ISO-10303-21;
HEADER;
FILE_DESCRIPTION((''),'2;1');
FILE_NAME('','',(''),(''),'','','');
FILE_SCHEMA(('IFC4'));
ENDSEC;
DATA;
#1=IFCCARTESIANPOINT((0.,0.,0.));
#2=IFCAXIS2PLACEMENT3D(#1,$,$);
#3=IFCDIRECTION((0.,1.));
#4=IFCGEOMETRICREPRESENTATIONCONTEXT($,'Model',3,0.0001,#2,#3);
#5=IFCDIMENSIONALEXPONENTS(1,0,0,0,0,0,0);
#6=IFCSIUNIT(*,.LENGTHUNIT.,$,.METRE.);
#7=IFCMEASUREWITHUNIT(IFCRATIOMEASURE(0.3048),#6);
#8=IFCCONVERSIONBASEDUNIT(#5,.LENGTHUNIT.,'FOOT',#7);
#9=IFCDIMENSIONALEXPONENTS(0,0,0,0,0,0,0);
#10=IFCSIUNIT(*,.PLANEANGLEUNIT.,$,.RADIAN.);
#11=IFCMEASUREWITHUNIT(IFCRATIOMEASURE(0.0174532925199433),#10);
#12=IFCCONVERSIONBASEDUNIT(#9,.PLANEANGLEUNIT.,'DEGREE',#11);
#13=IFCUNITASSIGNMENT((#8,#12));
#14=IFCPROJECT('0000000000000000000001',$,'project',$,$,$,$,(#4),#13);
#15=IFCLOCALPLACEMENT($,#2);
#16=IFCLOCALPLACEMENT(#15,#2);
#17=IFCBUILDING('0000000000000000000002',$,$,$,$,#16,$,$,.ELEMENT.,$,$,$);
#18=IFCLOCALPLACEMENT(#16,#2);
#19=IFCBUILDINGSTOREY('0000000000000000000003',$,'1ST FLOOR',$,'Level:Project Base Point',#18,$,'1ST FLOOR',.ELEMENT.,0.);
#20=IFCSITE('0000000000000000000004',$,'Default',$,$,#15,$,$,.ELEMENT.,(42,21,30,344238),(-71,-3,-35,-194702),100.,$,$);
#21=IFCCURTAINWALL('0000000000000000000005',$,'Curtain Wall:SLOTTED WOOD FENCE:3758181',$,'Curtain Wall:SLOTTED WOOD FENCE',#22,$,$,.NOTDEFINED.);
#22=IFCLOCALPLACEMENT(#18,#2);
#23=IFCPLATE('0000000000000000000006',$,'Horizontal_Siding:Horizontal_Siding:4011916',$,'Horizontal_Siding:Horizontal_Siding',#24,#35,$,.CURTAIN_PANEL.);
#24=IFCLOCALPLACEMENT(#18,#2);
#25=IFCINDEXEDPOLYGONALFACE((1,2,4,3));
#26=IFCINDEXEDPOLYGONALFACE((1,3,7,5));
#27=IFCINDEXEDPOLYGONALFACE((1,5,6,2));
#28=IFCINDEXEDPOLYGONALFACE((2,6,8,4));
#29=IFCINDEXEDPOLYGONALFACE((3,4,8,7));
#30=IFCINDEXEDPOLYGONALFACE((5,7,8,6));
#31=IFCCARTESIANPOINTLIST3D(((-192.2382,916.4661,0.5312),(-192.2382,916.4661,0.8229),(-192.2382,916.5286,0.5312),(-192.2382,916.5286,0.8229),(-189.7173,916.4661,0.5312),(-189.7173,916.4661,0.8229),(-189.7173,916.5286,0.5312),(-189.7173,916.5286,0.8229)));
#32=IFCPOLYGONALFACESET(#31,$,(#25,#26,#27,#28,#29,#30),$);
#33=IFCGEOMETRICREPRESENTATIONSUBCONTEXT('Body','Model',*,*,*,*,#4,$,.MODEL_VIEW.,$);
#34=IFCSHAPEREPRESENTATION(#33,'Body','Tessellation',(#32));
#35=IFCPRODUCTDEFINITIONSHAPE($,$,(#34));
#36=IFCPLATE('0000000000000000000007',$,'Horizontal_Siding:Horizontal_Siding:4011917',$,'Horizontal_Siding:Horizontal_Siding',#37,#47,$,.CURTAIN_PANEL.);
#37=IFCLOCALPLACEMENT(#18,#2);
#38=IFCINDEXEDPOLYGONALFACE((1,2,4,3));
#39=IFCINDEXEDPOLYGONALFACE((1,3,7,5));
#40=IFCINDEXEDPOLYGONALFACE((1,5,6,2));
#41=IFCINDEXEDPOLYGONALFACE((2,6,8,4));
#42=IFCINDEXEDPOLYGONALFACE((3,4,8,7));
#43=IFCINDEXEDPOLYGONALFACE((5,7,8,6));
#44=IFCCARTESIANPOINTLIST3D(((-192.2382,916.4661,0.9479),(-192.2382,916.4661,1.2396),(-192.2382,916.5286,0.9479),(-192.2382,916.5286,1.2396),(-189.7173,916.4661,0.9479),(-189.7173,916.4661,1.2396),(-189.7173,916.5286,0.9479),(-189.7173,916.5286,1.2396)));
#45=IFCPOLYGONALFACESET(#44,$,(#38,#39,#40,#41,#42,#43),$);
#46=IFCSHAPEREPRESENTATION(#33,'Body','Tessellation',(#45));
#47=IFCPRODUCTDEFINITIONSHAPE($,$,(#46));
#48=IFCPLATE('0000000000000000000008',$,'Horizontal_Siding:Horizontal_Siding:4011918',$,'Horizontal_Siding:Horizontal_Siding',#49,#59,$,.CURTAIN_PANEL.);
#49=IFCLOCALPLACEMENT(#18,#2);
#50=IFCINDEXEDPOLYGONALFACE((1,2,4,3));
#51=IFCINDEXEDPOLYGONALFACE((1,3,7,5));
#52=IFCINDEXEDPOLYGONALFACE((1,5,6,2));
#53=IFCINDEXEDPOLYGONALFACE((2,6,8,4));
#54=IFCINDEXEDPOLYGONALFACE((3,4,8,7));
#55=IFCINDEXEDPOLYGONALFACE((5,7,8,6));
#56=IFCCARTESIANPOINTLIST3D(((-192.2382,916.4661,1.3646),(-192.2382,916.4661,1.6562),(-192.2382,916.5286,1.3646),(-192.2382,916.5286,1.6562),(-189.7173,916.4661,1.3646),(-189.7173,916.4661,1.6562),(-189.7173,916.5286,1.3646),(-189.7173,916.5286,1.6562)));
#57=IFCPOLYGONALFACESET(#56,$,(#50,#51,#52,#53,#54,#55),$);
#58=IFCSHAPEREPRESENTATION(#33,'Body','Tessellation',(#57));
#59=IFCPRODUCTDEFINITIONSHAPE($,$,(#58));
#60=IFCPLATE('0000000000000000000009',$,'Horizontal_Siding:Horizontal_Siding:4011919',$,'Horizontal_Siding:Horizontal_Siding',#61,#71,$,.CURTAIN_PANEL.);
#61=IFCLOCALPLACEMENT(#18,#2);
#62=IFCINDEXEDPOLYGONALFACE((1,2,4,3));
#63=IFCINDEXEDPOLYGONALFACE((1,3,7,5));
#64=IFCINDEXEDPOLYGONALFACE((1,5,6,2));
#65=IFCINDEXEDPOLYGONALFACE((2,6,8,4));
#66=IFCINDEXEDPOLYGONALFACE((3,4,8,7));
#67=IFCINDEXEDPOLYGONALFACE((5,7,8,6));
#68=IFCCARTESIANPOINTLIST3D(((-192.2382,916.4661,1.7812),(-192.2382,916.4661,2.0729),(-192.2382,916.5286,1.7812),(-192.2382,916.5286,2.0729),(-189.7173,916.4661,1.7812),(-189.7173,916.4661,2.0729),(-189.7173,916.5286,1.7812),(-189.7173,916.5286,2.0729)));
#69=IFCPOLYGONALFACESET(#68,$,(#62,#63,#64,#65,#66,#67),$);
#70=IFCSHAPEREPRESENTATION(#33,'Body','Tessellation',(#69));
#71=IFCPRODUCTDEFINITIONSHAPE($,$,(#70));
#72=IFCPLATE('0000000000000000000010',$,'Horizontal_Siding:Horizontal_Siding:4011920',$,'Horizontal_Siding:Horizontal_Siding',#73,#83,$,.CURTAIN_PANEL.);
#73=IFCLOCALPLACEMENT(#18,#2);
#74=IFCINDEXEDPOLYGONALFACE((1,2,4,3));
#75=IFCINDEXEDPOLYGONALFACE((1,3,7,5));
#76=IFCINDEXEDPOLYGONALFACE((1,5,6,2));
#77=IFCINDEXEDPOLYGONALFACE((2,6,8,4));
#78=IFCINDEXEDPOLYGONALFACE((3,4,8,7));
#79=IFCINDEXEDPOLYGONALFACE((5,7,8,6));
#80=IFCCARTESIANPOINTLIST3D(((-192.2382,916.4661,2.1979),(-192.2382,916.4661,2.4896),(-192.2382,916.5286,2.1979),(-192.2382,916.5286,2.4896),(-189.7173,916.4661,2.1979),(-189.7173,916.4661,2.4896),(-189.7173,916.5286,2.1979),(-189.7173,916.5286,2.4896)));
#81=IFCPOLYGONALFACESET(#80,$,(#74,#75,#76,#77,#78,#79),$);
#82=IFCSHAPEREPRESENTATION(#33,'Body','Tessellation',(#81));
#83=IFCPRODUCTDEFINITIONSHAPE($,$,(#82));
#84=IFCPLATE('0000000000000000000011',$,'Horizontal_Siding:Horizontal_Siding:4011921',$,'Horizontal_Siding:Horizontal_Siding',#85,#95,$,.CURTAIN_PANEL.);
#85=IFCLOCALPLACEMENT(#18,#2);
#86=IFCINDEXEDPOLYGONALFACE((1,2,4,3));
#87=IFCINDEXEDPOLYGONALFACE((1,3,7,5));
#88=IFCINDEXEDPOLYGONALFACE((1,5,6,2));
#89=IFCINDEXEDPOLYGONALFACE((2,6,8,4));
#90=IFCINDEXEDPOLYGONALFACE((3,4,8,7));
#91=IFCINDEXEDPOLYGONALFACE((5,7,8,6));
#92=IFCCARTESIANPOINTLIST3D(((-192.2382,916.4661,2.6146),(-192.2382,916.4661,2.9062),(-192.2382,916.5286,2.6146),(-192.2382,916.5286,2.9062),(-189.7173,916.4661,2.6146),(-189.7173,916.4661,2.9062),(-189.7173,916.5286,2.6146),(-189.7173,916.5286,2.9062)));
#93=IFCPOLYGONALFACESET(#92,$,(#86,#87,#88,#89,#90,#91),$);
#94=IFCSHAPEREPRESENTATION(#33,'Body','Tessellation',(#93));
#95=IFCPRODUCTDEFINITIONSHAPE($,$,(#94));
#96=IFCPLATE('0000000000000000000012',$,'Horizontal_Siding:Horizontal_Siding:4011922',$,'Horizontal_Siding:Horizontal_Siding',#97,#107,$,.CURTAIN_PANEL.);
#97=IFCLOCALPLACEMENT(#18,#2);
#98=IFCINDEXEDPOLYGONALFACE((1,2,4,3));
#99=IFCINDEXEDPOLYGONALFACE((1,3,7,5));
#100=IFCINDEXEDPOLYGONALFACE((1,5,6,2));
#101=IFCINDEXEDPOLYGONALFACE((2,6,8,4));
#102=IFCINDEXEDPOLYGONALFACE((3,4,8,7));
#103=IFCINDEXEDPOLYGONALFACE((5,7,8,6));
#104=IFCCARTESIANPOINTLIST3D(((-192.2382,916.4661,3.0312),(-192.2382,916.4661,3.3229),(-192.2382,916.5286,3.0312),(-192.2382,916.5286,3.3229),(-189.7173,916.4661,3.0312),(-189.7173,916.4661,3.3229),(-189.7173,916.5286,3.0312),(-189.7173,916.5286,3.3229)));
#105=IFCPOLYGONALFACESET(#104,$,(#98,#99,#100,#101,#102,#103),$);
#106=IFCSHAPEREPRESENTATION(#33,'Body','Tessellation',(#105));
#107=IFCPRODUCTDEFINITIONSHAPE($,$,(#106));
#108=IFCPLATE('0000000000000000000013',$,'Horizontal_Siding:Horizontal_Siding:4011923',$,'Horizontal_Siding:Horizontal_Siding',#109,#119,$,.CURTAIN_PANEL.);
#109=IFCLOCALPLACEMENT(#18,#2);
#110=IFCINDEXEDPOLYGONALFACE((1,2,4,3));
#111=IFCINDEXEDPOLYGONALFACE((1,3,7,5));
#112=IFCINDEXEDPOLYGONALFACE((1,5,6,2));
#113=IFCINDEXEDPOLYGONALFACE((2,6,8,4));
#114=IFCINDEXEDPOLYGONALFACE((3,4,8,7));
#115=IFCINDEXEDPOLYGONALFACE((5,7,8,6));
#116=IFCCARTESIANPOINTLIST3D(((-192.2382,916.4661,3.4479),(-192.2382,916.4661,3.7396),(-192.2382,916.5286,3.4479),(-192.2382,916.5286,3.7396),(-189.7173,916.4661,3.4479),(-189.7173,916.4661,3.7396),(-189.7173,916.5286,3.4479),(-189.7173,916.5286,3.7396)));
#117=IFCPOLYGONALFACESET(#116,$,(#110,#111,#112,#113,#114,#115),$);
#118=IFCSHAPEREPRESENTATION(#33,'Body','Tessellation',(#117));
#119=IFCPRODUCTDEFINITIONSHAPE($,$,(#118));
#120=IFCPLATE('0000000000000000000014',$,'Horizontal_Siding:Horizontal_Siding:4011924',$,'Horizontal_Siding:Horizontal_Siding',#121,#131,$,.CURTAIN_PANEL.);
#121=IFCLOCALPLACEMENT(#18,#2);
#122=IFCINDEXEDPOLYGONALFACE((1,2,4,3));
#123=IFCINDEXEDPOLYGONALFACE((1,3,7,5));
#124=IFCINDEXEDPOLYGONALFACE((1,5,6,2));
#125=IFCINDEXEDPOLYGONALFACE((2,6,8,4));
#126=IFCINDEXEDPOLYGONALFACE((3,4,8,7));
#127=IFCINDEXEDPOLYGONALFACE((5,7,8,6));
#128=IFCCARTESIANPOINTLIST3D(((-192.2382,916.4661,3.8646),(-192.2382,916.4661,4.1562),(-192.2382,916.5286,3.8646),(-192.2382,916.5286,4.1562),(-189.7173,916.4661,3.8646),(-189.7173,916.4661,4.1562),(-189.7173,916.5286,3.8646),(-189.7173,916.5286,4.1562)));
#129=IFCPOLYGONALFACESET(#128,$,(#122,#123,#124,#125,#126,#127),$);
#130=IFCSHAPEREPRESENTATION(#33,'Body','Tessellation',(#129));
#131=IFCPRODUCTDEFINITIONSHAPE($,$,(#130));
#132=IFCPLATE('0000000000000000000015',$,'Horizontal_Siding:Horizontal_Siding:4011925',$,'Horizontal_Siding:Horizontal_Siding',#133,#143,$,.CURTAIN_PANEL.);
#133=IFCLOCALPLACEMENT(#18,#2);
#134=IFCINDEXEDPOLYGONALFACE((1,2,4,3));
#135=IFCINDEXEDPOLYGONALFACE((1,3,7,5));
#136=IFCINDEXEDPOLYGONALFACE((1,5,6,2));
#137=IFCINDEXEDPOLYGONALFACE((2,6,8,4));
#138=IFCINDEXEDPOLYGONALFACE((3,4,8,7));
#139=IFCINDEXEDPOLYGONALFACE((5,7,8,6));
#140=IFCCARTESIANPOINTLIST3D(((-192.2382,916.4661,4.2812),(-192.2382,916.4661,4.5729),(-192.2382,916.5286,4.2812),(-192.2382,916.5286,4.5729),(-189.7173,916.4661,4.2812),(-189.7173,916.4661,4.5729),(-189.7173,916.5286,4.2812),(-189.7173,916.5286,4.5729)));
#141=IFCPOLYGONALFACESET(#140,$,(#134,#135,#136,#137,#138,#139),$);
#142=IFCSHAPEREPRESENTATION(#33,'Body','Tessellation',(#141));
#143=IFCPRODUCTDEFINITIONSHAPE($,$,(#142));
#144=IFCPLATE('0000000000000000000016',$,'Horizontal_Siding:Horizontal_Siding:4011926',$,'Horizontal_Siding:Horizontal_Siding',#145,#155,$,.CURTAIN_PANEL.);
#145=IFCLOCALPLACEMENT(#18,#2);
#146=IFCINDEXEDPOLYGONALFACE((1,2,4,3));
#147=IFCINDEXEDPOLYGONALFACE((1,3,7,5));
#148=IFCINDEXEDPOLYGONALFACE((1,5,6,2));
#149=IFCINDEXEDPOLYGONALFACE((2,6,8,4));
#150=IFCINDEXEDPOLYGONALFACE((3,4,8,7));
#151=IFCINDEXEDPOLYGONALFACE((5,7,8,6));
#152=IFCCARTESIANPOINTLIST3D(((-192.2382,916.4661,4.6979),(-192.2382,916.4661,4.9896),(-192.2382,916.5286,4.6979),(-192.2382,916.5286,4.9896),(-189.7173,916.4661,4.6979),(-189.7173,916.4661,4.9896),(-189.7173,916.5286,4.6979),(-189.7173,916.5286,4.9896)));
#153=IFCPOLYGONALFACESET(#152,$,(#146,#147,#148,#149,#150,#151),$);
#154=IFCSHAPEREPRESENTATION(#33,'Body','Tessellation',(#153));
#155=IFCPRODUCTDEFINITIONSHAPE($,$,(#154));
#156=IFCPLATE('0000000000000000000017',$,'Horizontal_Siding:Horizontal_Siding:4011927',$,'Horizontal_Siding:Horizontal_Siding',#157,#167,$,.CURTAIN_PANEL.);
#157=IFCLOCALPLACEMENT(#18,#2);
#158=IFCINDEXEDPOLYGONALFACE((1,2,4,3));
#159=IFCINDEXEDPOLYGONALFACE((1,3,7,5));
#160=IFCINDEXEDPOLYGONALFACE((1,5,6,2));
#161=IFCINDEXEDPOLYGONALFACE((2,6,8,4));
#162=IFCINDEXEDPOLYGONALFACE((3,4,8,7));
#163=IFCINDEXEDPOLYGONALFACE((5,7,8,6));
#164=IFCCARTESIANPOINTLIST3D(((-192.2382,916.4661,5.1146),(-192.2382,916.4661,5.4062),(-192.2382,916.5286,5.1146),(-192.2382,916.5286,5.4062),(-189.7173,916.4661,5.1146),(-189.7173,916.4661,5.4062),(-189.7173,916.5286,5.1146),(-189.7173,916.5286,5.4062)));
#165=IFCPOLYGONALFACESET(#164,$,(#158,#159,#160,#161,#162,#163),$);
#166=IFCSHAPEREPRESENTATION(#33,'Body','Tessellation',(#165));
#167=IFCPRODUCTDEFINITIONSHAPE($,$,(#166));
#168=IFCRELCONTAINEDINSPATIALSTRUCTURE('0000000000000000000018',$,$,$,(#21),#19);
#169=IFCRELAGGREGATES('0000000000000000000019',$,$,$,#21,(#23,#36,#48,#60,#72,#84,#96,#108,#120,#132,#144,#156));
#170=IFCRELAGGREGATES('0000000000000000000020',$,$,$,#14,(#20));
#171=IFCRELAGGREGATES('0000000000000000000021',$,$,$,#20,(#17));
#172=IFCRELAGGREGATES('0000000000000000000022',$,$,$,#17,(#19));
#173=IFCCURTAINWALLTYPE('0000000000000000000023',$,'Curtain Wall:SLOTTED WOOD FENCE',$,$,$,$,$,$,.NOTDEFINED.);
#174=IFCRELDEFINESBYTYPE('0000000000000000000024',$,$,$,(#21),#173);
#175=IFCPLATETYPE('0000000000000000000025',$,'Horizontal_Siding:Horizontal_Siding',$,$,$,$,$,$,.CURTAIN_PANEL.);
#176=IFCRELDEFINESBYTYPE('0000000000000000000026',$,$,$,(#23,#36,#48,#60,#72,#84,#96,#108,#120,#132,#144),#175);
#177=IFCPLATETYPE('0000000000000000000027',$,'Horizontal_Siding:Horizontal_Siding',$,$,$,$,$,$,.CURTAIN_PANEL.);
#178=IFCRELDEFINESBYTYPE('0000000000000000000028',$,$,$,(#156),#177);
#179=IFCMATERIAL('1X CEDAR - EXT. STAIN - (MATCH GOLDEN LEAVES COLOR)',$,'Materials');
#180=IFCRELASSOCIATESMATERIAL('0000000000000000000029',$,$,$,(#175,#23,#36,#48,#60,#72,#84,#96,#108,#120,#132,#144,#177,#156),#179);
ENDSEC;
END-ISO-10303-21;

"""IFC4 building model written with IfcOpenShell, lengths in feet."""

from ifc_helpers import new_model, entity, si_unit, converted_unit, direction, frame, origin, origin_2d_with_axis, place, context, subcontext, project, spatial, rectangle, extrude, source, transform, mapped, material, type_object, type_shapes, element, aggregate, save


model = new_model("IFC4")

# Units and contexts
model_context = context("Model", 3, precision=0.0001, world=origin(), true_north=direction((0.0, 1.0)))
body_context = subcontext(model_context, "Body", "Model", "MODEL_VIEW")
ifc_project = project(units=[converted_unit("LENGTHUNIT", "FOOT", entity("IfcRatioMeasure", 0.3048), si_unit("LENGTHUNIT", "METRE"), dimensions=[1, 0, 0, 0, 0, 0, 0]), converted_unit("PLANEANGLEUNIT", "DEGREE", entity("IfcRatioMeasure", 0.0174532925199433), si_unit("PLANEANGLEUNIT", "RADIAN"), dimensions=[0, 0, 0, 0, 0, 0, 0])], contexts=[model_context])

# Site, building, storey
site_placement = place(None, origin())
site = spatial("IfcSite", under=ifc_project, at=site_placement, Name="Default", CompositionType="ELEMENT", RefLatitude=(42, 21, 30, 344238), RefLongitude=(-71, -3, -35, -194702), RefElevation=100.0)
building_placement = place(site_placement, origin())
building = spatial("IfcBuilding", under=site, at=building_placement, CompositionType="ELEMENT")
storey_placement = place(building_placement, origin())
storey = spatial("IfcBuildingStorey", under=building, at=storey_placement, Name="1ST FLOOR", ObjectType="Level:Project Base Point", LongName="1ST FLOOR", CompositionType="ELEMENT", Elevation=0.0)

# Curtain wall, plates
curtain_wall_type = type_object("IfcCurtainWallType", Name="Curtain Wall:SLOTTED WOOD FENCE", PredefinedType="NOTDEFINED")
curtain_wall_placement = place(storey_placement, origin())
curtain_wall = element("IfcCurtainWall", 1, at=curtain_wall_placement, inside=storey, type_object=curtain_wall_type, Name="Curtain Wall:SLOTTED WOOD FENCE:3758181", ObjectType="Curtain Wall:SLOTTED WOOD FENCE", PredefinedType="NOTDEFINED")
ifc_material_1 = material(Name="1X CEDAR - EXT. STAIN - (MATCH GOLDEN LEAVES COLOR)", Category="Materials")
plate_type_1 = type_object("IfcPlateType", Name="Horizontal_Siding:Horizontal_Siding", PredefinedType="CURTAIN_PANEL", material=ifc_material_1)
shared_shape_1 = source(origin(), body_context, "Body", "SweptSolid", [
    extrude(rectangle(XDim=2.5208, YDim=0.0625, at=origin_2d_with_axis()), frame((1.2604, 0.0312, 0.0), z_axis=(0.0, 0.0, 1.0), x_axis=(-1.0, 0.0, 0.0)), (0.0, 0.0, 1.0), 0.2917),
])
type_shapes(plate_type_1, [shared_shape_1])
plate_1_placement = place(curtain_wall_placement, frame((-192.2382, 916.4661, 0.5312)))
plate_1 = element("IfcPlate", 2, at=plate_1_placement, type_object=plate_type_1, material=ifc_material_1, Name="Horizontal_Siding:Horizontal_Siding:4011916", ObjectType="Horizontal_Siding:Horizontal_Siding", PredefinedType="CURTAIN_PANEL", context=body_context, shape_type="MappedRepresentation", body=[
    mapped(shared_shape_1, transform((0.0, 0.0, 0.0), scale=1.0)),
])
plate_2_placement = place(curtain_wall_placement, frame((-192.2382, 916.4661, 0.9479)))
plate_2 = element("IfcPlate", 3, at=plate_2_placement, type_object=plate_type_1, material=ifc_material_1, Name="Horizontal_Siding:Horizontal_Siding:4011917", ObjectType="Horizontal_Siding:Horizontal_Siding", PredefinedType="CURTAIN_PANEL", context=body_context, shape_type="MappedRepresentation", body=[
    mapped(shared_shape_1, transform((0.0, 0.0, 0.0), scale=1.0)),
])
plate_3_placement = place(curtain_wall_placement, frame((-192.2382, 916.4661, 1.3646)))
plate_3 = element("IfcPlate", 4, at=plate_3_placement, type_object=plate_type_1, material=ifc_material_1, Name="Horizontal_Siding:Horizontal_Siding:4011918", ObjectType="Horizontal_Siding:Horizontal_Siding", PredefinedType="CURTAIN_PANEL", context=body_context, shape_type="MappedRepresentation", body=[
    mapped(shared_shape_1, transform((0.0, 0.0, 0.0), scale=1.0)),
])
plate_4_placement = place(curtain_wall_placement, frame((-192.2382, 916.4661, 1.7812)))
plate_4 = element("IfcPlate", 5, at=plate_4_placement, type_object=plate_type_1, material=ifc_material_1, Name="Horizontal_Siding:Horizontal_Siding:4011919", ObjectType="Horizontal_Siding:Horizontal_Siding", PredefinedType="CURTAIN_PANEL", context=body_context, shape_type="MappedRepresentation", body=[
    mapped(shared_shape_1, transform((0.0, 0.0, 0.0), scale=1.0)),
])
plate_5_placement = place(curtain_wall_placement, frame((-192.2382, 916.4661, 2.1979)))
plate_5 = element("IfcPlate", 6, at=plate_5_placement, type_object=plate_type_1, material=ifc_material_1, Name="Horizontal_Siding:Horizontal_Siding:4011920", ObjectType="Horizontal_Siding:Horizontal_Siding", PredefinedType="CURTAIN_PANEL", context=body_context, shape_type="MappedRepresentation", body=[
    mapped(shared_shape_1, transform((0.0, 0.0, 0.0), scale=1.0)),
])
plate_6_placement = place(curtain_wall_placement, frame((-192.2382, 916.4661, 2.6146)))
plate_6 = element("IfcPlate", 7, at=plate_6_placement, type_object=plate_type_1, material=ifc_material_1, Name="Horizontal_Siding:Horizontal_Siding:4011921", ObjectType="Horizontal_Siding:Horizontal_Siding", PredefinedType="CURTAIN_PANEL", context=body_context, shape_type="MappedRepresentation", body=[
    mapped(shared_shape_1, transform((0.0, 0.0, 0.0), scale=1.0)),
])
plate_7_placement = place(curtain_wall_placement, frame((-192.2382, 916.4661, 3.0312)))
plate_7 = element("IfcPlate", 8, at=plate_7_placement, type_object=plate_type_1, material=ifc_material_1, Name="Horizontal_Siding:Horizontal_Siding:4011922", ObjectType="Horizontal_Siding:Horizontal_Siding", PredefinedType="CURTAIN_PANEL", context=body_context, shape_type="MappedRepresentation", body=[
    mapped(shared_shape_1, transform((0.0, 0.0, 0.0), scale=1.0)),
])
plate_8_placement = place(curtain_wall_placement, frame((-192.2382, 916.4661, 3.4479)))
plate_8 = element("IfcPlate", 9, at=plate_8_placement, type_object=plate_type_1, material=ifc_material_1, Name="Horizontal_Siding:Horizontal_Siding:4011923", ObjectType="Horizontal_Siding:Horizontal_Siding", PredefinedType="CURTAIN_PANEL", context=body_context, shape_type="MappedRepresentation", body=[
    mapped(shared_shape_1, transform((0.0, 0.0, 0.0), scale=1.0)),
])
plate_9_placement = place(curtain_wall_placement, frame((-192.2382, 916.4661, 3.8646)))
plate_9 = element("IfcPlate", 10, at=plate_9_placement, type_object=plate_type_1, material=ifc_material_1, Name="Horizontal_Siding:Horizontal_Siding:4011924", ObjectType="Horizontal_Siding:Horizontal_Siding", PredefinedType="CURTAIN_PANEL", context=body_context, shape_type="MappedRepresentation", body=[
    mapped(shared_shape_1, transform((0.0, 0.0, 0.0), scale=1.0)),
])
plate_10_placement = place(curtain_wall_placement, frame((-192.2382, 916.4661, 4.2812)))
plate_10 = element("IfcPlate", 11, at=plate_10_placement, type_object=plate_type_1, material=ifc_material_1, Name="Horizontal_Siding:Horizontal_Siding:4011925", ObjectType="Horizontal_Siding:Horizontal_Siding", PredefinedType="CURTAIN_PANEL", context=body_context, shape_type="MappedRepresentation", body=[
    mapped(shared_shape_1, transform((0.0, 0.0, 0.0), scale=1.0)),
])
plate_11_placement = place(curtain_wall_placement, frame((-192.2382, 916.4661, 4.6979)))
plate_11 = element("IfcPlate", 12, at=plate_11_placement, type_object=plate_type_1, material=ifc_material_1, Name="Horizontal_Siding:Horizontal_Siding:4011926", ObjectType="Horizontal_Siding:Horizontal_Siding", PredefinedType="CURTAIN_PANEL", context=body_context, shape_type="MappedRepresentation", body=[
    mapped(shared_shape_1, transform((0.0, 0.0, 0.0), scale=1.0)),
])
plate_type_2 = type_object("IfcPlateType", Name="Horizontal_Siding:Horizontal_Siding", PredefinedType="CURTAIN_PANEL", material=ifc_material_1)
shared_shape_2 = source(origin(), body_context, "Body", "SweptSolid", [
    extrude(rectangle(XDim=2.5208, YDim=0.0625, at=origin_2d_with_axis()), frame((1.2604, 0.0312, 0.0), z_axis=(0.0, 0.0, 1.0), x_axis=(-1.0, 0.0, 0.0)), (0.0, 0.0, 1.0), 0.2917),
])
type_shapes(plate_type_2, [shared_shape_2])
plate_12_placement = place(curtain_wall_placement, frame((-192.2382, 916.4661, 5.1146)))
plate_12 = element("IfcPlate", 13, at=plate_12_placement, type_object=plate_type_2, material=ifc_material_1, Name="Horizontal_Siding:Horizontal_Siding:4011927", ObjectType="Horizontal_Siding:Horizontal_Siding", PredefinedType="CURTAIN_PANEL", context=body_context, shape_type="MappedRepresentation", body=[
    mapped(shared_shape_2, transform((0.0, 0.0, 0.0), scale=1.0)),
])
aggregate(curtain_wall, [plate_1, plate_2, plate_3, plate_4, plate_5, plate_6, plate_7, plate_8, plate_9, plate_10, plate_11, plate_12])

save(model, "model.ifc")
